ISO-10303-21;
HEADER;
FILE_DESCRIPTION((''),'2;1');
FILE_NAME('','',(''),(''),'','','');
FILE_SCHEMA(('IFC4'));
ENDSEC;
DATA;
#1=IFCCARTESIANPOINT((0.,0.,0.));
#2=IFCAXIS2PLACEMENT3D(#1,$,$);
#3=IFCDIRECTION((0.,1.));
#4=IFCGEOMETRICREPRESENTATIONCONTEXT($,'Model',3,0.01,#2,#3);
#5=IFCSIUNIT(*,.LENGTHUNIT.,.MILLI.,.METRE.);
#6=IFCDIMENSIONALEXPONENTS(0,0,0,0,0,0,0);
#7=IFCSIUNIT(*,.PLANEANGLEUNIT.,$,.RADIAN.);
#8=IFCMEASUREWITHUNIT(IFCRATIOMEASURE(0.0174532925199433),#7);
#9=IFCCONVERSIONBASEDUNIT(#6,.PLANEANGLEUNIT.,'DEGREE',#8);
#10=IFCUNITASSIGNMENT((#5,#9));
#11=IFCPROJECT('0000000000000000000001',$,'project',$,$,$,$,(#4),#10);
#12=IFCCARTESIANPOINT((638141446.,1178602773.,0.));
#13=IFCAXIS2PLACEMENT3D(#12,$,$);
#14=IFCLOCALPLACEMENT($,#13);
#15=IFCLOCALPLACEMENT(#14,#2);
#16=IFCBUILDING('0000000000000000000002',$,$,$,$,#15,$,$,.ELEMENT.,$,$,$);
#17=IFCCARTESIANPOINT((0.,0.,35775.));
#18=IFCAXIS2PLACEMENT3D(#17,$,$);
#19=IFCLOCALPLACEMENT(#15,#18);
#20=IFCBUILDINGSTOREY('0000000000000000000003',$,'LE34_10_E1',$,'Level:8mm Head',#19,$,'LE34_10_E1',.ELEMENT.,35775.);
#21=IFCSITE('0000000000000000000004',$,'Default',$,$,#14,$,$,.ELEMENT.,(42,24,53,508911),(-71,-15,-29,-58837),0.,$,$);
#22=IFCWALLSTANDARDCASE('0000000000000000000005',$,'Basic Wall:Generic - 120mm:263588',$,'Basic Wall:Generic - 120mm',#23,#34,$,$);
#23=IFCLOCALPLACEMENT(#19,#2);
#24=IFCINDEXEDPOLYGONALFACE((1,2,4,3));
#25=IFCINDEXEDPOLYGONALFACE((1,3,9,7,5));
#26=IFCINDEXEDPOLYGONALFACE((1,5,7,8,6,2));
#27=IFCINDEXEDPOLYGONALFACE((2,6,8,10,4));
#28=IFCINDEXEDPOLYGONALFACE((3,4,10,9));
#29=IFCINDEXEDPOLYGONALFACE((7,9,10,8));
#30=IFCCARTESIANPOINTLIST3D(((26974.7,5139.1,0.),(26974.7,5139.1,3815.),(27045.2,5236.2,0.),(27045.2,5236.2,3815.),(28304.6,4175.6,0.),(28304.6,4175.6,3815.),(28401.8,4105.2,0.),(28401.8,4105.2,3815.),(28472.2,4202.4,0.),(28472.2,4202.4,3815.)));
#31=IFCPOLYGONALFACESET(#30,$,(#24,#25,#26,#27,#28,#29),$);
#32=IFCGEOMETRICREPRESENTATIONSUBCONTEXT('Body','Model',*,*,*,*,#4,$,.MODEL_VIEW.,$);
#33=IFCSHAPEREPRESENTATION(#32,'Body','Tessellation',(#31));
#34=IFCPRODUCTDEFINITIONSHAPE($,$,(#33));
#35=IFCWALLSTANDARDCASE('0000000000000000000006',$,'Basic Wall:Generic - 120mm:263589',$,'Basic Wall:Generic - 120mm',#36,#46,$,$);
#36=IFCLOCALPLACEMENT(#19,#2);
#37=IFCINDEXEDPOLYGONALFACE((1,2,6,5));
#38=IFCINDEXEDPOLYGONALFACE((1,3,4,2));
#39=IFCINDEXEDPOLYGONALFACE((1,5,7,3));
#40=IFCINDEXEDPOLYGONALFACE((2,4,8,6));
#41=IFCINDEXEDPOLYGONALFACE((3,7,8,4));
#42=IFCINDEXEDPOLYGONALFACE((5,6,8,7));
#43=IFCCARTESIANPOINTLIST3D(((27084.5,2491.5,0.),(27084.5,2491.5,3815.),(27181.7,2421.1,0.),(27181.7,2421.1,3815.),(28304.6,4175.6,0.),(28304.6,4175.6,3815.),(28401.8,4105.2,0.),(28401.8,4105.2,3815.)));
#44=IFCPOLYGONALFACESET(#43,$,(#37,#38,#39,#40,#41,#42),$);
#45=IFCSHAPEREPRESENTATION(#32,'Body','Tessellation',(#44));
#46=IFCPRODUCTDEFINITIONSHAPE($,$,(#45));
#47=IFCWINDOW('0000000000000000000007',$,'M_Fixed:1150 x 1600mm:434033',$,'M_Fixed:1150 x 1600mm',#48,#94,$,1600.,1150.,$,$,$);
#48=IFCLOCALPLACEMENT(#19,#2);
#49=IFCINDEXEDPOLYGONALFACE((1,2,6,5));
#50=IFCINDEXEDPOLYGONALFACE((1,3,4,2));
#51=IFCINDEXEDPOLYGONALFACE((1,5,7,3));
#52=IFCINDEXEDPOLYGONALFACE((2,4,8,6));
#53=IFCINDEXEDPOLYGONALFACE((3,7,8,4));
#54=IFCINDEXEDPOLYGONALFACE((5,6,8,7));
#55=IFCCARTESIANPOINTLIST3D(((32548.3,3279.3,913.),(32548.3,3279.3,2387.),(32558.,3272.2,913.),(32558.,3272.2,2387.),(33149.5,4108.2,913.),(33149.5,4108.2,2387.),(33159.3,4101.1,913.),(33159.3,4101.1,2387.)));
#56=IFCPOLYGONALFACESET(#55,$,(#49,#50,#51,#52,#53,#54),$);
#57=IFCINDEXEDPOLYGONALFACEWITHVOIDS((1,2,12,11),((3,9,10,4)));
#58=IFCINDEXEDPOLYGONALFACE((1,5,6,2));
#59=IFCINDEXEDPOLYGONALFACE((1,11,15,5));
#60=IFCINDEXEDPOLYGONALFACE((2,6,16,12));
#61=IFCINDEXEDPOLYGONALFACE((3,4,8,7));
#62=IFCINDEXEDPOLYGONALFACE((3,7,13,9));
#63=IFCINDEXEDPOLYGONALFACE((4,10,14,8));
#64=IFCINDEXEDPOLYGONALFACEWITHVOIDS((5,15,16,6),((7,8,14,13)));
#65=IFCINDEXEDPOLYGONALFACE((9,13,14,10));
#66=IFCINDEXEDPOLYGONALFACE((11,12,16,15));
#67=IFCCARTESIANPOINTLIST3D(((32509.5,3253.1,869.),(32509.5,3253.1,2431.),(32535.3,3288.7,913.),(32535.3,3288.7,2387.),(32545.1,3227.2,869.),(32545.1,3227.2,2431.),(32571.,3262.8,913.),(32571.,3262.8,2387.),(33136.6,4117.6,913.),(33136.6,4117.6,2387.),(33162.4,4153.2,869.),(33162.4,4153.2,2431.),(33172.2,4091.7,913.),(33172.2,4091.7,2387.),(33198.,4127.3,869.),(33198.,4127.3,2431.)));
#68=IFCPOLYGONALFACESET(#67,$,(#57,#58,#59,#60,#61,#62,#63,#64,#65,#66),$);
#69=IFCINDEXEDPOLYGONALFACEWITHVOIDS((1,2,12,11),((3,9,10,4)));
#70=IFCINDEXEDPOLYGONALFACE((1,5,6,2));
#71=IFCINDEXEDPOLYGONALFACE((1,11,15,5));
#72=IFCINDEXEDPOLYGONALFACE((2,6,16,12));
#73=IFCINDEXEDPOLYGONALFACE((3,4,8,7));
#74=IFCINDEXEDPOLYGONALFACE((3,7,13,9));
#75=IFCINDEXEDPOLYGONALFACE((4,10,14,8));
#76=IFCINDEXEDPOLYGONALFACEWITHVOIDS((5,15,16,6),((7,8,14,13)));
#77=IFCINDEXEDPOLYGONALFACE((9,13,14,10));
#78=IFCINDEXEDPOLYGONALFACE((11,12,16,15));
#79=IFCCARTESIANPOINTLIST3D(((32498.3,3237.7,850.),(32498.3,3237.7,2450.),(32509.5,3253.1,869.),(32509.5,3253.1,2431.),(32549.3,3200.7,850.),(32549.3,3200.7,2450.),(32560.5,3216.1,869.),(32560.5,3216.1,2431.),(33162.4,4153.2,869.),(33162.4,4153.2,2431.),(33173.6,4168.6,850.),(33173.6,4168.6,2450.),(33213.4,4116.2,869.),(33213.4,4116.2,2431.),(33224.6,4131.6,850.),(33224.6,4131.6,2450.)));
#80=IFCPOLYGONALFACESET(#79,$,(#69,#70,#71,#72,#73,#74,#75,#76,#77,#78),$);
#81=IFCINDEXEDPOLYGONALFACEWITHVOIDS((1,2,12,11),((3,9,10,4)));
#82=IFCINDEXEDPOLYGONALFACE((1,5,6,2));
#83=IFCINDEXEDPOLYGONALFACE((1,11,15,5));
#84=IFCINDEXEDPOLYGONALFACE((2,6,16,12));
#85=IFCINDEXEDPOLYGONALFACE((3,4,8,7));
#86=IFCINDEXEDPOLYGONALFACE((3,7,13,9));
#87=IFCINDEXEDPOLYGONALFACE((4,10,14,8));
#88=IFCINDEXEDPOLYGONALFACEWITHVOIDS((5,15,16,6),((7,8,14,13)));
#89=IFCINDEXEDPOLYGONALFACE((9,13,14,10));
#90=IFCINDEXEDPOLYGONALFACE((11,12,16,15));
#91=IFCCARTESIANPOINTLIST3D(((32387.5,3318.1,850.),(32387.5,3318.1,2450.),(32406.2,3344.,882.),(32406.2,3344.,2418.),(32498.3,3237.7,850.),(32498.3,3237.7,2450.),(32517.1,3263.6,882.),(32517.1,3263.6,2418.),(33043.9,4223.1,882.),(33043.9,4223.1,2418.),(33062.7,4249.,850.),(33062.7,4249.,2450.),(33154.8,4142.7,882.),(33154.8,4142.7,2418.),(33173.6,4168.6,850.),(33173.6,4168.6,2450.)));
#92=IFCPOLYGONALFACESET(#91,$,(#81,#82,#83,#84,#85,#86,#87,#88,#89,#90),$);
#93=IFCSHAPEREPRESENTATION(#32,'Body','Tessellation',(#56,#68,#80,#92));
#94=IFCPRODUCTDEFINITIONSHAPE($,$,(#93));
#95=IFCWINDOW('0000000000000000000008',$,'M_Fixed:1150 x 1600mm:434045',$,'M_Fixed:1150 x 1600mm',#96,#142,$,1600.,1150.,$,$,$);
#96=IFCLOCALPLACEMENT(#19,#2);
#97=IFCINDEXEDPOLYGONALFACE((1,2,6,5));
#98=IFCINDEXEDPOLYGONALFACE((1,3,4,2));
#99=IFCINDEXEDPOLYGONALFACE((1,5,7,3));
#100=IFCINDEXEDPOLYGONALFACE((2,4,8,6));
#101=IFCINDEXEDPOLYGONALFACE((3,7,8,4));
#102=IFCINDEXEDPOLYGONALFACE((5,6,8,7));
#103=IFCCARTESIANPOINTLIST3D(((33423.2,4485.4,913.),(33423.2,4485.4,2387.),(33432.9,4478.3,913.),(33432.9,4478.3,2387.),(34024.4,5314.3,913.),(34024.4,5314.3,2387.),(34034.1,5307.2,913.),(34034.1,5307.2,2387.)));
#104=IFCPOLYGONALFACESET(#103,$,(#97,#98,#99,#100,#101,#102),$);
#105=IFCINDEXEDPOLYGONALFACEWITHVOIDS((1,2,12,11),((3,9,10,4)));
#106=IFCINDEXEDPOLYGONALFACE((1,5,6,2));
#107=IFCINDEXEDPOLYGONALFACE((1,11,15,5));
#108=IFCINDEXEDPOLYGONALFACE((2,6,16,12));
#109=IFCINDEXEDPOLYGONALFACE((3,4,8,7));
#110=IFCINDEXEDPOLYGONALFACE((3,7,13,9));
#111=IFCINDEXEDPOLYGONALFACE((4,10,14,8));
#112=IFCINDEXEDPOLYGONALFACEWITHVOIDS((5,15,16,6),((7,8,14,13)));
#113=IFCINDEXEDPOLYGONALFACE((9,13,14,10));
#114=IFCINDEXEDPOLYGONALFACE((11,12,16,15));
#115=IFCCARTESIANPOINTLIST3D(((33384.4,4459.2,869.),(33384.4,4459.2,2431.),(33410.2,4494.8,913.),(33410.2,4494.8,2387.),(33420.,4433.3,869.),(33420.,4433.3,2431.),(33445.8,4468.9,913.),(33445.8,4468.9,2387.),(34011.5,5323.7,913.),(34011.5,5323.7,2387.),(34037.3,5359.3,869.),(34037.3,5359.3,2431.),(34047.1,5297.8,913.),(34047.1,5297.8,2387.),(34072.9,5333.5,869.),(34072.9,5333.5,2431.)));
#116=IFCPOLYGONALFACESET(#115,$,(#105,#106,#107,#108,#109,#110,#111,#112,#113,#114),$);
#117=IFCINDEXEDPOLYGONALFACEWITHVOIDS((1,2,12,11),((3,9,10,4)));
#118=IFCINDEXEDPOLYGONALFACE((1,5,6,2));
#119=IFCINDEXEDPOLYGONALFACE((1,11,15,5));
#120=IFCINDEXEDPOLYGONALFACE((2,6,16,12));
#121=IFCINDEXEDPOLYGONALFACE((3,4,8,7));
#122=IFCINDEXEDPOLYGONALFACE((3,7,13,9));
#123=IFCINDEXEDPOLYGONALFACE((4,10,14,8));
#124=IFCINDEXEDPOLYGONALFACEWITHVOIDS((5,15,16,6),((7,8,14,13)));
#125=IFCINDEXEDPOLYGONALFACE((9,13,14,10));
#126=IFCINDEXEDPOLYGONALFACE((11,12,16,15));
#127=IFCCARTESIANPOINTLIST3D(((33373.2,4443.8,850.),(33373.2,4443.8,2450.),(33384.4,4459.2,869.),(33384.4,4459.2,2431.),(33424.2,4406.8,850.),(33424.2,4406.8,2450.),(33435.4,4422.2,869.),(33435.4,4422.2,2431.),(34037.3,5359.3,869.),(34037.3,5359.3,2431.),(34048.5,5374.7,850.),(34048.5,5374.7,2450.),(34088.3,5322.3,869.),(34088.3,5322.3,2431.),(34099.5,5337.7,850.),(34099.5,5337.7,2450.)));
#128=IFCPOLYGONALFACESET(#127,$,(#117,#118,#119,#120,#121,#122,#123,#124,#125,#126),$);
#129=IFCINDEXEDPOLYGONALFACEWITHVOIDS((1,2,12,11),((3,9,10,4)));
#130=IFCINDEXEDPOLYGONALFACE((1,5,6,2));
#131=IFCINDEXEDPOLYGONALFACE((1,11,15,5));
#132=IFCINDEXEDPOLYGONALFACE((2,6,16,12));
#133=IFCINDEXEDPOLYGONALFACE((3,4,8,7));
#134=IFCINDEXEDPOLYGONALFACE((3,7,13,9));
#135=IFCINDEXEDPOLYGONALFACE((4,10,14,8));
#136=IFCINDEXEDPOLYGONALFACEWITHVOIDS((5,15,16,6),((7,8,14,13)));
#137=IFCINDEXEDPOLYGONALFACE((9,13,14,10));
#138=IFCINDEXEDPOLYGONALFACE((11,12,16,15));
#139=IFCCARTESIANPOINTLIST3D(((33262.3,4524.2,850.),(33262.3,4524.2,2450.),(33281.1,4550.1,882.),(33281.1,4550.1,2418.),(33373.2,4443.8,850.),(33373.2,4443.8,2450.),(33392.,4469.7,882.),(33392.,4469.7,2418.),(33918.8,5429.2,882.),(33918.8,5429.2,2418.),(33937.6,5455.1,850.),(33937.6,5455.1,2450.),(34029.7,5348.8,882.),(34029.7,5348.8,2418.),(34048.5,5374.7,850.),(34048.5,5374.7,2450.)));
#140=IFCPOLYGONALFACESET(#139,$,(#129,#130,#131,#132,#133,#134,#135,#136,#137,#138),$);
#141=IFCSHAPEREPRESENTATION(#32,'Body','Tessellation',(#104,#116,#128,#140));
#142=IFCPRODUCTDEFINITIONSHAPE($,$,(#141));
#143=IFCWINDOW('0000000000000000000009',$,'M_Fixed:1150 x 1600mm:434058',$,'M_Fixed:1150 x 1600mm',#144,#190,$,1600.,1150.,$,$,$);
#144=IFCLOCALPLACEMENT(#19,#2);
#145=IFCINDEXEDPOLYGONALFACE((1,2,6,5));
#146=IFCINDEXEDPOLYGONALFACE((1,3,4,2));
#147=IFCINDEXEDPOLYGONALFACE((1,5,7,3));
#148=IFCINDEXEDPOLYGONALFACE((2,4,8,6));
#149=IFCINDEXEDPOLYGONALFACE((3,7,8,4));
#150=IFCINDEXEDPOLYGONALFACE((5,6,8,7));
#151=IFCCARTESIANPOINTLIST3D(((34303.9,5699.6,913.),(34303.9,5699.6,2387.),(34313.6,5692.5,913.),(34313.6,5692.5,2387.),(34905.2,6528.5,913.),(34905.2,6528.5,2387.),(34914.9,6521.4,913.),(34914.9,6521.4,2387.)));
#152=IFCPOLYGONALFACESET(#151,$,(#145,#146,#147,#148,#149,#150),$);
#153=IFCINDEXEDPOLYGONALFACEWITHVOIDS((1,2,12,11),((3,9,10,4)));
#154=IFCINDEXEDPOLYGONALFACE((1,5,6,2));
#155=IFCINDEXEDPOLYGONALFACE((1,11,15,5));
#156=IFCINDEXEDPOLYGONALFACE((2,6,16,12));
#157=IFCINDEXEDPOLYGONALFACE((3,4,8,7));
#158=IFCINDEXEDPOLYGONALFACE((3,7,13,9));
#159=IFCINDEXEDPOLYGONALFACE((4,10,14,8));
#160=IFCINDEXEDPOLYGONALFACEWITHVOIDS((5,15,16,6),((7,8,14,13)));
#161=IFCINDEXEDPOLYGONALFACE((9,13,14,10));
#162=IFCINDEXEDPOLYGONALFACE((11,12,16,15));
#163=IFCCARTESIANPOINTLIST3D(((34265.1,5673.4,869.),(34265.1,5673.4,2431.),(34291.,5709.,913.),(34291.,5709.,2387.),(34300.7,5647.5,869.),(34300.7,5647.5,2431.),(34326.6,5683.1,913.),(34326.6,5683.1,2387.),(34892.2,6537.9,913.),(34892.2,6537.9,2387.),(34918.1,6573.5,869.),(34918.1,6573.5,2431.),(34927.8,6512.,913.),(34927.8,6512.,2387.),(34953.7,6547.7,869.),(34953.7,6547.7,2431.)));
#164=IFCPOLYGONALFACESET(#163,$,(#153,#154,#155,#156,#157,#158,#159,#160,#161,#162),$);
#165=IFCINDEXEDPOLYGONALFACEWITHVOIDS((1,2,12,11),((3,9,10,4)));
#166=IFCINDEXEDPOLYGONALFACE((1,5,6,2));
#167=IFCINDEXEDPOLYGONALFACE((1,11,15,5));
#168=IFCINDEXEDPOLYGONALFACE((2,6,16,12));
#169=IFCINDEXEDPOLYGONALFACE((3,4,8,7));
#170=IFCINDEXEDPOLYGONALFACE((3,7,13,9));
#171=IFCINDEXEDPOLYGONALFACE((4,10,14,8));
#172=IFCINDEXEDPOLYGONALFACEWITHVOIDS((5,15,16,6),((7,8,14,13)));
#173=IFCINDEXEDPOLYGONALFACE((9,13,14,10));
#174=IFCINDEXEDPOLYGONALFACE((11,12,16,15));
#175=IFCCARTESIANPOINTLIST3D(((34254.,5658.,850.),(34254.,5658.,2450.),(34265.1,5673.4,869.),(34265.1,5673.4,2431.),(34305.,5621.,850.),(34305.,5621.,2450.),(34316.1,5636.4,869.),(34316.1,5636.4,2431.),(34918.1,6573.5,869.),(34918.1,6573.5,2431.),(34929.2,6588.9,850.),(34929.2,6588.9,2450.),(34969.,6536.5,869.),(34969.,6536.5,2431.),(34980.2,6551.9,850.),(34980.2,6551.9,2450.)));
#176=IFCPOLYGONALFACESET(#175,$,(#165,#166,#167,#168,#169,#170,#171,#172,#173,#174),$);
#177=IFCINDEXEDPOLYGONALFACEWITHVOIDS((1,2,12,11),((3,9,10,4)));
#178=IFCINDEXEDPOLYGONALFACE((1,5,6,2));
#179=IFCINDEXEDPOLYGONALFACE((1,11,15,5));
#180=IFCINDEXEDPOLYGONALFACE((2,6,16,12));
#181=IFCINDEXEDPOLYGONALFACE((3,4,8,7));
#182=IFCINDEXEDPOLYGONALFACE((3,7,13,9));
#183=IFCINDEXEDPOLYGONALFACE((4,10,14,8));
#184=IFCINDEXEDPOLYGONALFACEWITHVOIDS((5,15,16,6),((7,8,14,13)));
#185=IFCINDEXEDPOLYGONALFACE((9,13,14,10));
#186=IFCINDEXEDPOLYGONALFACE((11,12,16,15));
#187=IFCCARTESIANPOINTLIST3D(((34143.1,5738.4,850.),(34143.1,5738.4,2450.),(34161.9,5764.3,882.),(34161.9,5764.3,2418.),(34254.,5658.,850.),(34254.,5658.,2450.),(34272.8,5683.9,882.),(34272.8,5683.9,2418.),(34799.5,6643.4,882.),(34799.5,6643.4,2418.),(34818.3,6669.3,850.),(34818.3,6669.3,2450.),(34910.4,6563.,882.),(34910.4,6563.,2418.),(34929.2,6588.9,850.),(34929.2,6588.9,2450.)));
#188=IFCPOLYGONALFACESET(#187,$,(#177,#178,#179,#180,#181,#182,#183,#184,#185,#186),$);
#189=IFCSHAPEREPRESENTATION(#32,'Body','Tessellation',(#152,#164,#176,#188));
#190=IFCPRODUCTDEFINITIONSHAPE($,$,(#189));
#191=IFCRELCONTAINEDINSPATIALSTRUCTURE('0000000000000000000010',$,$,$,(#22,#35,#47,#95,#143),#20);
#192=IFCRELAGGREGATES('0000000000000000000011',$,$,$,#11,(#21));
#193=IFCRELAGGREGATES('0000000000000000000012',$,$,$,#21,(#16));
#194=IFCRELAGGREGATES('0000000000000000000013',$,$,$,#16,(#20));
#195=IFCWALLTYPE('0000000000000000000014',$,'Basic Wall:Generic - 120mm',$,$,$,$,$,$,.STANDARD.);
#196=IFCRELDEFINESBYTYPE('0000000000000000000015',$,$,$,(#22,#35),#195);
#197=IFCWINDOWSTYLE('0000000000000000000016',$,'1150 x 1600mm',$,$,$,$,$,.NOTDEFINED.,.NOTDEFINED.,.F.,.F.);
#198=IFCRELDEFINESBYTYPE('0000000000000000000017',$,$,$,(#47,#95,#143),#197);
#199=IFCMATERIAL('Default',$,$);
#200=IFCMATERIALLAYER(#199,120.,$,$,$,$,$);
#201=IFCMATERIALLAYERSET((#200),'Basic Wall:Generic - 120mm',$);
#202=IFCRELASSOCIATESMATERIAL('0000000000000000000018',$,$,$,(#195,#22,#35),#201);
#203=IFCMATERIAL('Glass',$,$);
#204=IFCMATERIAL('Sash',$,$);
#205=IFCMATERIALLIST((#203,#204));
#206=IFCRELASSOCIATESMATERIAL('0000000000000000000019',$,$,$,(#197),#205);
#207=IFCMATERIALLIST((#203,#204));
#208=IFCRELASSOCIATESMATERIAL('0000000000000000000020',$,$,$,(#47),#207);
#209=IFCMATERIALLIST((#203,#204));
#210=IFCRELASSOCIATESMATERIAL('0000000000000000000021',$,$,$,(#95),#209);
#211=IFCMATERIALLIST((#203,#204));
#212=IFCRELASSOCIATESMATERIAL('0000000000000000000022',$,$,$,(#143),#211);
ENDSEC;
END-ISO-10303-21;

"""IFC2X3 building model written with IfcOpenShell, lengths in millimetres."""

from ifc_helpers import new_model, entity, si_unit, converted_unit, direction, frame, frame_2d, origin, place, context, subcontext, project, spatial, polyline, rectangle, outline, extrude, source, transform, mapped, material, material_list, layer, layer_set, layer_usage, type_object, type_shapes, element, save


model = new_model("IFC2X3")

# Units and contexts
model_context = context("Model", 3, precision=0.01, world=origin(), true_north=direction((0.0, 1.0)))
body_context = subcontext(model_context, "Body", "Model", "MODEL_VIEW")
ifc_project = project(units=[si_unit("LENGTHUNIT", "METRE", prefix="MILLI"), converted_unit("PLANEANGLEUNIT", "DEGREE", entity("IfcRatioMeasure", 0.0174532925199433), si_unit("PLANEANGLEUNIT", "RADIAN"), dimensions=[0, 0, 0, 0, 0, 0, 0])], contexts=[model_context])

# Site, building, storey
site_placement = place(None, frame((638141446.0, 1178602773.0, 0.0)))
site = spatial("IfcSite", under=ifc_project, at=site_placement, Name="Default", CompositionType="ELEMENT", RefLatitude=(42, 24, 53, 508911), RefLongitude=(-71, -15, -29, -58837), RefElevation=0.0)
building_placement = place(site_placement, origin())
building = spatial("IfcBuilding", under=site, at=building_placement, CompositionType="ELEMENT")
storey_placement = place(building_placement, frame((0.0, 0.0, 35775.0)))
storey = spatial("IfcBuildingStorey", under=building, at=storey_placement, Name="LE34_10_E1", ObjectType="Level:8mm Head", LongName="LE34_10_E1", CompositionType="ELEMENT", Elevation=35775.0)

# Walls
ifc_material_1 = material(Name="Default")
ifc_layer_1 = layer(ifc_material_1, 120.0)
ifc_layer_set_1 = layer_set([ifc_layer_1], Name="Basic Wall:Generic - 120mm")
ifc_layer_usage_1 = layer_usage(ifc_layer_set_1, "AXIS2", "NEGATIVE", 60.0)
wall_type_1 = type_object("IfcWallType", Name="Basic Wall:Generic - 120mm", PredefinedType="STANDARD", material=ifc_layer_set_1)
wall_1_placement = place(storey_placement, frame((28437.0, 4153.8, 0.0), z_axis=(0.0, 0.0, 1.0), x_axis=(-0.809804, 0.5867, 0.0)))
element("IfcWallStandardCase", 1, at=wall_1_placement, inside=storey, type_object=wall_type_1, material=ifc_layer_usage_1, Name="Basic Wall:Generic - 120mm:263588", ObjectType="Basic Wall:Generic - 120mm", context=body_context, shape_type="SweptSolid", body=[
    extrude(outline(polyline([(1762.1, -60.0), (1762.3, 60.0), (120.0, 60.0), (0.0, 60.0), (0.0, -60.0), (1762.1, -60.0)])), origin(), (0.0, 0.0, 1.0), 3815.0),
])
ifc_layer_usage_2 = layer_usage(ifc_layer_set_1, "AXIS2", "NEGATIVE", 60.0)
wall_2_placement = place(storey_placement, frame((28353.2, 4140.4, 0.0), z_axis=(0.0, 0.0, 1.0), x_axis=(-0.5867, -0.809804, 0.0)))
element("IfcWallStandardCase", 2, at=wall_2_placement, inside=storey, type_object=wall_type_1, material=ifc_layer_usage_2, Name="Basic Wall:Generic - 120mm:263589", ObjectType="Basic Wall:Generic - 120mm", context=body_context, shape_type="SweptSolid", body=[
    extrude(rectangle(XDim=2079.6, YDim=120.0, at=frame_2d((1039.8, 0.0), x_axis=(-1.0, 0.0))), origin(), (0.0, 0.0, 1.0), 3815.0),
])

# Windows
ifc_material_2 = material(Name="Glass")
ifc_material_3 = material(Name="Sash")
ifc_material_list_1 = material_list([ifc_material_2, ifc_material_3])
ifc_material_list_2 = material_list([ifc_material_2, ifc_material_3])
window_style = type_object("IfcWindowStyle", Name="1150 x 1600mm", ConstructionType="NOTDEFINED", OperationType="NOTDEFINED", ParameterTakesPrecedence=False, Sizeable=False, material=ifc_material_list_2)
shared_shape = source(origin(), body_context, "Body", "SweptSolid", [
    extrude(rectangle(XDim=1024.0, YDim=12.0, at=frame_2d((0.0, 0.0), x_axis=(1.0, 0.0))), frame((575.0, 295.0, 63.0), z_axis=(0.0, 0.0, 1.0), x_axis=(-1.0, 0.0, 0.0)), (0.0, 0.0, 1.0), 1474.0),
    extrude(outline(polyline([(-556.0, -781.0), (556.0, -781.0), (556.0, 781.0), (-556.0, 781.0), (-556.0, -781.0)]), holes=[polyline([(-512.0, -737.0), (-512.0, 737.0), (512.0, 737.0), (512.0, -737.0), (-512.0, -737.0)])]), frame((575.0, 317.0, 800.0), z_axis=(0.0, -1.0, 0.0), x_axis=(-1.0, 0.0, 0.0)), (0.0, 0.0, 1.0), 44.0),
    extrude(outline(polyline([(-575.0, -800.0), (575.0, -800.0), (575.0, 800.0), (-575.0, 800.0), (-575.0, -800.0)]), holes=[polyline([(-556.0, -781.0), (-556.0, 781.0), (556.0, 781.0), (556.0, -781.0), (-556.0, -781.0)])]), frame((575.0, 336.0, 800.0), z_axis=(0.0, -1.0, 0.0), x_axis=(-1.0, 0.0, 0.0)), (0.0, 0.0, 1.0), 63.0),
    extrude(outline(polyline([(-575.0, -800.0), (575.0, -800.0), (575.0, 800.0), (-575.0, 800.0), (-575.0, -800.0)]), holes=[polyline([(-543.0, -768.0), (-543.0, 768.0), (543.0, 768.0), (543.0, -768.0), (-543.0, -768.0)])]), frame((575.0, 273.0, 800.0), z_axis=(0.0, -1.0, 0.0), x_axis=(-1.0, 0.0, 0.0)), (0.0, 0.0, 1.0), 137.0),
])
type_shapes(window_style, [shared_shape])
window_1_placement = place(storey_placement, frame((32952.6, 4328.9, 850.0), z_axis=(0.0, 0.0, 1.0), x_axis=(-0.587164, -0.809468, 0.0)))
element("IfcWindow", 3, at=window_1_placement, inside=storey, type_object=window_style, material=ifc_material_list_1, Name="M_Fixed:1150 x 1600mm:434033", ObjectType="M_Fixed:1150 x 1600mm", OverallHeight=1600.0, OverallWidth=1150.0, context=body_context, shape_type="MappedRepresentation", body=[
    mapped(shared_shape, transform((0.0, 0.0, 0.0), scale=1.0)),
])
ifc_material_list_3 = material_list([ifc_material_2, ifc_material_3])
window_2_placement = place(storey_placement, frame((33827.5, 5535.0, 850.0), z_axis=(0.0, 0.0, 1.0), x_axis=(-0.587164, -0.809468, 0.0)))
element("IfcWindow", 4, at=window_2_placement, inside=storey, type_object=window_style, material=ifc_material_list_3, Name="M_Fixed:1150 x 1600mm:434045", ObjectType="M_Fixed:1150 x 1600mm", OverallHeight=1600.0, OverallWidth=1150.0, context=body_context, shape_type="MappedRepresentation", body=[
    mapped(shared_shape, transform((0.0, 0.0, 0.0), scale=1.0)),
])
ifc_material_list_4 = material_list([ifc_material_2, ifc_material_3])
window_3_placement = place(storey_placement, frame((34708.2, 6749.2, 850.0), z_axis=(0.0, 0.0, 1.0), x_axis=(-0.587164, -0.809468, 0.0)))
element("IfcWindow", 5, at=window_3_placement, inside=storey, type_object=window_style, material=ifc_material_list_4, Name="M_Fixed:1150 x 1600mm:434058", ObjectType="M_Fixed:1150 x 1600mm", OverallHeight=1600.0, OverallWidth=1150.0, context=body_context, shape_type="MappedRepresentation", body=[
    mapped(shared_shape, transform((0.0, 0.0, 0.0), scale=1.0)),
])

save(model, "model.ifc")
